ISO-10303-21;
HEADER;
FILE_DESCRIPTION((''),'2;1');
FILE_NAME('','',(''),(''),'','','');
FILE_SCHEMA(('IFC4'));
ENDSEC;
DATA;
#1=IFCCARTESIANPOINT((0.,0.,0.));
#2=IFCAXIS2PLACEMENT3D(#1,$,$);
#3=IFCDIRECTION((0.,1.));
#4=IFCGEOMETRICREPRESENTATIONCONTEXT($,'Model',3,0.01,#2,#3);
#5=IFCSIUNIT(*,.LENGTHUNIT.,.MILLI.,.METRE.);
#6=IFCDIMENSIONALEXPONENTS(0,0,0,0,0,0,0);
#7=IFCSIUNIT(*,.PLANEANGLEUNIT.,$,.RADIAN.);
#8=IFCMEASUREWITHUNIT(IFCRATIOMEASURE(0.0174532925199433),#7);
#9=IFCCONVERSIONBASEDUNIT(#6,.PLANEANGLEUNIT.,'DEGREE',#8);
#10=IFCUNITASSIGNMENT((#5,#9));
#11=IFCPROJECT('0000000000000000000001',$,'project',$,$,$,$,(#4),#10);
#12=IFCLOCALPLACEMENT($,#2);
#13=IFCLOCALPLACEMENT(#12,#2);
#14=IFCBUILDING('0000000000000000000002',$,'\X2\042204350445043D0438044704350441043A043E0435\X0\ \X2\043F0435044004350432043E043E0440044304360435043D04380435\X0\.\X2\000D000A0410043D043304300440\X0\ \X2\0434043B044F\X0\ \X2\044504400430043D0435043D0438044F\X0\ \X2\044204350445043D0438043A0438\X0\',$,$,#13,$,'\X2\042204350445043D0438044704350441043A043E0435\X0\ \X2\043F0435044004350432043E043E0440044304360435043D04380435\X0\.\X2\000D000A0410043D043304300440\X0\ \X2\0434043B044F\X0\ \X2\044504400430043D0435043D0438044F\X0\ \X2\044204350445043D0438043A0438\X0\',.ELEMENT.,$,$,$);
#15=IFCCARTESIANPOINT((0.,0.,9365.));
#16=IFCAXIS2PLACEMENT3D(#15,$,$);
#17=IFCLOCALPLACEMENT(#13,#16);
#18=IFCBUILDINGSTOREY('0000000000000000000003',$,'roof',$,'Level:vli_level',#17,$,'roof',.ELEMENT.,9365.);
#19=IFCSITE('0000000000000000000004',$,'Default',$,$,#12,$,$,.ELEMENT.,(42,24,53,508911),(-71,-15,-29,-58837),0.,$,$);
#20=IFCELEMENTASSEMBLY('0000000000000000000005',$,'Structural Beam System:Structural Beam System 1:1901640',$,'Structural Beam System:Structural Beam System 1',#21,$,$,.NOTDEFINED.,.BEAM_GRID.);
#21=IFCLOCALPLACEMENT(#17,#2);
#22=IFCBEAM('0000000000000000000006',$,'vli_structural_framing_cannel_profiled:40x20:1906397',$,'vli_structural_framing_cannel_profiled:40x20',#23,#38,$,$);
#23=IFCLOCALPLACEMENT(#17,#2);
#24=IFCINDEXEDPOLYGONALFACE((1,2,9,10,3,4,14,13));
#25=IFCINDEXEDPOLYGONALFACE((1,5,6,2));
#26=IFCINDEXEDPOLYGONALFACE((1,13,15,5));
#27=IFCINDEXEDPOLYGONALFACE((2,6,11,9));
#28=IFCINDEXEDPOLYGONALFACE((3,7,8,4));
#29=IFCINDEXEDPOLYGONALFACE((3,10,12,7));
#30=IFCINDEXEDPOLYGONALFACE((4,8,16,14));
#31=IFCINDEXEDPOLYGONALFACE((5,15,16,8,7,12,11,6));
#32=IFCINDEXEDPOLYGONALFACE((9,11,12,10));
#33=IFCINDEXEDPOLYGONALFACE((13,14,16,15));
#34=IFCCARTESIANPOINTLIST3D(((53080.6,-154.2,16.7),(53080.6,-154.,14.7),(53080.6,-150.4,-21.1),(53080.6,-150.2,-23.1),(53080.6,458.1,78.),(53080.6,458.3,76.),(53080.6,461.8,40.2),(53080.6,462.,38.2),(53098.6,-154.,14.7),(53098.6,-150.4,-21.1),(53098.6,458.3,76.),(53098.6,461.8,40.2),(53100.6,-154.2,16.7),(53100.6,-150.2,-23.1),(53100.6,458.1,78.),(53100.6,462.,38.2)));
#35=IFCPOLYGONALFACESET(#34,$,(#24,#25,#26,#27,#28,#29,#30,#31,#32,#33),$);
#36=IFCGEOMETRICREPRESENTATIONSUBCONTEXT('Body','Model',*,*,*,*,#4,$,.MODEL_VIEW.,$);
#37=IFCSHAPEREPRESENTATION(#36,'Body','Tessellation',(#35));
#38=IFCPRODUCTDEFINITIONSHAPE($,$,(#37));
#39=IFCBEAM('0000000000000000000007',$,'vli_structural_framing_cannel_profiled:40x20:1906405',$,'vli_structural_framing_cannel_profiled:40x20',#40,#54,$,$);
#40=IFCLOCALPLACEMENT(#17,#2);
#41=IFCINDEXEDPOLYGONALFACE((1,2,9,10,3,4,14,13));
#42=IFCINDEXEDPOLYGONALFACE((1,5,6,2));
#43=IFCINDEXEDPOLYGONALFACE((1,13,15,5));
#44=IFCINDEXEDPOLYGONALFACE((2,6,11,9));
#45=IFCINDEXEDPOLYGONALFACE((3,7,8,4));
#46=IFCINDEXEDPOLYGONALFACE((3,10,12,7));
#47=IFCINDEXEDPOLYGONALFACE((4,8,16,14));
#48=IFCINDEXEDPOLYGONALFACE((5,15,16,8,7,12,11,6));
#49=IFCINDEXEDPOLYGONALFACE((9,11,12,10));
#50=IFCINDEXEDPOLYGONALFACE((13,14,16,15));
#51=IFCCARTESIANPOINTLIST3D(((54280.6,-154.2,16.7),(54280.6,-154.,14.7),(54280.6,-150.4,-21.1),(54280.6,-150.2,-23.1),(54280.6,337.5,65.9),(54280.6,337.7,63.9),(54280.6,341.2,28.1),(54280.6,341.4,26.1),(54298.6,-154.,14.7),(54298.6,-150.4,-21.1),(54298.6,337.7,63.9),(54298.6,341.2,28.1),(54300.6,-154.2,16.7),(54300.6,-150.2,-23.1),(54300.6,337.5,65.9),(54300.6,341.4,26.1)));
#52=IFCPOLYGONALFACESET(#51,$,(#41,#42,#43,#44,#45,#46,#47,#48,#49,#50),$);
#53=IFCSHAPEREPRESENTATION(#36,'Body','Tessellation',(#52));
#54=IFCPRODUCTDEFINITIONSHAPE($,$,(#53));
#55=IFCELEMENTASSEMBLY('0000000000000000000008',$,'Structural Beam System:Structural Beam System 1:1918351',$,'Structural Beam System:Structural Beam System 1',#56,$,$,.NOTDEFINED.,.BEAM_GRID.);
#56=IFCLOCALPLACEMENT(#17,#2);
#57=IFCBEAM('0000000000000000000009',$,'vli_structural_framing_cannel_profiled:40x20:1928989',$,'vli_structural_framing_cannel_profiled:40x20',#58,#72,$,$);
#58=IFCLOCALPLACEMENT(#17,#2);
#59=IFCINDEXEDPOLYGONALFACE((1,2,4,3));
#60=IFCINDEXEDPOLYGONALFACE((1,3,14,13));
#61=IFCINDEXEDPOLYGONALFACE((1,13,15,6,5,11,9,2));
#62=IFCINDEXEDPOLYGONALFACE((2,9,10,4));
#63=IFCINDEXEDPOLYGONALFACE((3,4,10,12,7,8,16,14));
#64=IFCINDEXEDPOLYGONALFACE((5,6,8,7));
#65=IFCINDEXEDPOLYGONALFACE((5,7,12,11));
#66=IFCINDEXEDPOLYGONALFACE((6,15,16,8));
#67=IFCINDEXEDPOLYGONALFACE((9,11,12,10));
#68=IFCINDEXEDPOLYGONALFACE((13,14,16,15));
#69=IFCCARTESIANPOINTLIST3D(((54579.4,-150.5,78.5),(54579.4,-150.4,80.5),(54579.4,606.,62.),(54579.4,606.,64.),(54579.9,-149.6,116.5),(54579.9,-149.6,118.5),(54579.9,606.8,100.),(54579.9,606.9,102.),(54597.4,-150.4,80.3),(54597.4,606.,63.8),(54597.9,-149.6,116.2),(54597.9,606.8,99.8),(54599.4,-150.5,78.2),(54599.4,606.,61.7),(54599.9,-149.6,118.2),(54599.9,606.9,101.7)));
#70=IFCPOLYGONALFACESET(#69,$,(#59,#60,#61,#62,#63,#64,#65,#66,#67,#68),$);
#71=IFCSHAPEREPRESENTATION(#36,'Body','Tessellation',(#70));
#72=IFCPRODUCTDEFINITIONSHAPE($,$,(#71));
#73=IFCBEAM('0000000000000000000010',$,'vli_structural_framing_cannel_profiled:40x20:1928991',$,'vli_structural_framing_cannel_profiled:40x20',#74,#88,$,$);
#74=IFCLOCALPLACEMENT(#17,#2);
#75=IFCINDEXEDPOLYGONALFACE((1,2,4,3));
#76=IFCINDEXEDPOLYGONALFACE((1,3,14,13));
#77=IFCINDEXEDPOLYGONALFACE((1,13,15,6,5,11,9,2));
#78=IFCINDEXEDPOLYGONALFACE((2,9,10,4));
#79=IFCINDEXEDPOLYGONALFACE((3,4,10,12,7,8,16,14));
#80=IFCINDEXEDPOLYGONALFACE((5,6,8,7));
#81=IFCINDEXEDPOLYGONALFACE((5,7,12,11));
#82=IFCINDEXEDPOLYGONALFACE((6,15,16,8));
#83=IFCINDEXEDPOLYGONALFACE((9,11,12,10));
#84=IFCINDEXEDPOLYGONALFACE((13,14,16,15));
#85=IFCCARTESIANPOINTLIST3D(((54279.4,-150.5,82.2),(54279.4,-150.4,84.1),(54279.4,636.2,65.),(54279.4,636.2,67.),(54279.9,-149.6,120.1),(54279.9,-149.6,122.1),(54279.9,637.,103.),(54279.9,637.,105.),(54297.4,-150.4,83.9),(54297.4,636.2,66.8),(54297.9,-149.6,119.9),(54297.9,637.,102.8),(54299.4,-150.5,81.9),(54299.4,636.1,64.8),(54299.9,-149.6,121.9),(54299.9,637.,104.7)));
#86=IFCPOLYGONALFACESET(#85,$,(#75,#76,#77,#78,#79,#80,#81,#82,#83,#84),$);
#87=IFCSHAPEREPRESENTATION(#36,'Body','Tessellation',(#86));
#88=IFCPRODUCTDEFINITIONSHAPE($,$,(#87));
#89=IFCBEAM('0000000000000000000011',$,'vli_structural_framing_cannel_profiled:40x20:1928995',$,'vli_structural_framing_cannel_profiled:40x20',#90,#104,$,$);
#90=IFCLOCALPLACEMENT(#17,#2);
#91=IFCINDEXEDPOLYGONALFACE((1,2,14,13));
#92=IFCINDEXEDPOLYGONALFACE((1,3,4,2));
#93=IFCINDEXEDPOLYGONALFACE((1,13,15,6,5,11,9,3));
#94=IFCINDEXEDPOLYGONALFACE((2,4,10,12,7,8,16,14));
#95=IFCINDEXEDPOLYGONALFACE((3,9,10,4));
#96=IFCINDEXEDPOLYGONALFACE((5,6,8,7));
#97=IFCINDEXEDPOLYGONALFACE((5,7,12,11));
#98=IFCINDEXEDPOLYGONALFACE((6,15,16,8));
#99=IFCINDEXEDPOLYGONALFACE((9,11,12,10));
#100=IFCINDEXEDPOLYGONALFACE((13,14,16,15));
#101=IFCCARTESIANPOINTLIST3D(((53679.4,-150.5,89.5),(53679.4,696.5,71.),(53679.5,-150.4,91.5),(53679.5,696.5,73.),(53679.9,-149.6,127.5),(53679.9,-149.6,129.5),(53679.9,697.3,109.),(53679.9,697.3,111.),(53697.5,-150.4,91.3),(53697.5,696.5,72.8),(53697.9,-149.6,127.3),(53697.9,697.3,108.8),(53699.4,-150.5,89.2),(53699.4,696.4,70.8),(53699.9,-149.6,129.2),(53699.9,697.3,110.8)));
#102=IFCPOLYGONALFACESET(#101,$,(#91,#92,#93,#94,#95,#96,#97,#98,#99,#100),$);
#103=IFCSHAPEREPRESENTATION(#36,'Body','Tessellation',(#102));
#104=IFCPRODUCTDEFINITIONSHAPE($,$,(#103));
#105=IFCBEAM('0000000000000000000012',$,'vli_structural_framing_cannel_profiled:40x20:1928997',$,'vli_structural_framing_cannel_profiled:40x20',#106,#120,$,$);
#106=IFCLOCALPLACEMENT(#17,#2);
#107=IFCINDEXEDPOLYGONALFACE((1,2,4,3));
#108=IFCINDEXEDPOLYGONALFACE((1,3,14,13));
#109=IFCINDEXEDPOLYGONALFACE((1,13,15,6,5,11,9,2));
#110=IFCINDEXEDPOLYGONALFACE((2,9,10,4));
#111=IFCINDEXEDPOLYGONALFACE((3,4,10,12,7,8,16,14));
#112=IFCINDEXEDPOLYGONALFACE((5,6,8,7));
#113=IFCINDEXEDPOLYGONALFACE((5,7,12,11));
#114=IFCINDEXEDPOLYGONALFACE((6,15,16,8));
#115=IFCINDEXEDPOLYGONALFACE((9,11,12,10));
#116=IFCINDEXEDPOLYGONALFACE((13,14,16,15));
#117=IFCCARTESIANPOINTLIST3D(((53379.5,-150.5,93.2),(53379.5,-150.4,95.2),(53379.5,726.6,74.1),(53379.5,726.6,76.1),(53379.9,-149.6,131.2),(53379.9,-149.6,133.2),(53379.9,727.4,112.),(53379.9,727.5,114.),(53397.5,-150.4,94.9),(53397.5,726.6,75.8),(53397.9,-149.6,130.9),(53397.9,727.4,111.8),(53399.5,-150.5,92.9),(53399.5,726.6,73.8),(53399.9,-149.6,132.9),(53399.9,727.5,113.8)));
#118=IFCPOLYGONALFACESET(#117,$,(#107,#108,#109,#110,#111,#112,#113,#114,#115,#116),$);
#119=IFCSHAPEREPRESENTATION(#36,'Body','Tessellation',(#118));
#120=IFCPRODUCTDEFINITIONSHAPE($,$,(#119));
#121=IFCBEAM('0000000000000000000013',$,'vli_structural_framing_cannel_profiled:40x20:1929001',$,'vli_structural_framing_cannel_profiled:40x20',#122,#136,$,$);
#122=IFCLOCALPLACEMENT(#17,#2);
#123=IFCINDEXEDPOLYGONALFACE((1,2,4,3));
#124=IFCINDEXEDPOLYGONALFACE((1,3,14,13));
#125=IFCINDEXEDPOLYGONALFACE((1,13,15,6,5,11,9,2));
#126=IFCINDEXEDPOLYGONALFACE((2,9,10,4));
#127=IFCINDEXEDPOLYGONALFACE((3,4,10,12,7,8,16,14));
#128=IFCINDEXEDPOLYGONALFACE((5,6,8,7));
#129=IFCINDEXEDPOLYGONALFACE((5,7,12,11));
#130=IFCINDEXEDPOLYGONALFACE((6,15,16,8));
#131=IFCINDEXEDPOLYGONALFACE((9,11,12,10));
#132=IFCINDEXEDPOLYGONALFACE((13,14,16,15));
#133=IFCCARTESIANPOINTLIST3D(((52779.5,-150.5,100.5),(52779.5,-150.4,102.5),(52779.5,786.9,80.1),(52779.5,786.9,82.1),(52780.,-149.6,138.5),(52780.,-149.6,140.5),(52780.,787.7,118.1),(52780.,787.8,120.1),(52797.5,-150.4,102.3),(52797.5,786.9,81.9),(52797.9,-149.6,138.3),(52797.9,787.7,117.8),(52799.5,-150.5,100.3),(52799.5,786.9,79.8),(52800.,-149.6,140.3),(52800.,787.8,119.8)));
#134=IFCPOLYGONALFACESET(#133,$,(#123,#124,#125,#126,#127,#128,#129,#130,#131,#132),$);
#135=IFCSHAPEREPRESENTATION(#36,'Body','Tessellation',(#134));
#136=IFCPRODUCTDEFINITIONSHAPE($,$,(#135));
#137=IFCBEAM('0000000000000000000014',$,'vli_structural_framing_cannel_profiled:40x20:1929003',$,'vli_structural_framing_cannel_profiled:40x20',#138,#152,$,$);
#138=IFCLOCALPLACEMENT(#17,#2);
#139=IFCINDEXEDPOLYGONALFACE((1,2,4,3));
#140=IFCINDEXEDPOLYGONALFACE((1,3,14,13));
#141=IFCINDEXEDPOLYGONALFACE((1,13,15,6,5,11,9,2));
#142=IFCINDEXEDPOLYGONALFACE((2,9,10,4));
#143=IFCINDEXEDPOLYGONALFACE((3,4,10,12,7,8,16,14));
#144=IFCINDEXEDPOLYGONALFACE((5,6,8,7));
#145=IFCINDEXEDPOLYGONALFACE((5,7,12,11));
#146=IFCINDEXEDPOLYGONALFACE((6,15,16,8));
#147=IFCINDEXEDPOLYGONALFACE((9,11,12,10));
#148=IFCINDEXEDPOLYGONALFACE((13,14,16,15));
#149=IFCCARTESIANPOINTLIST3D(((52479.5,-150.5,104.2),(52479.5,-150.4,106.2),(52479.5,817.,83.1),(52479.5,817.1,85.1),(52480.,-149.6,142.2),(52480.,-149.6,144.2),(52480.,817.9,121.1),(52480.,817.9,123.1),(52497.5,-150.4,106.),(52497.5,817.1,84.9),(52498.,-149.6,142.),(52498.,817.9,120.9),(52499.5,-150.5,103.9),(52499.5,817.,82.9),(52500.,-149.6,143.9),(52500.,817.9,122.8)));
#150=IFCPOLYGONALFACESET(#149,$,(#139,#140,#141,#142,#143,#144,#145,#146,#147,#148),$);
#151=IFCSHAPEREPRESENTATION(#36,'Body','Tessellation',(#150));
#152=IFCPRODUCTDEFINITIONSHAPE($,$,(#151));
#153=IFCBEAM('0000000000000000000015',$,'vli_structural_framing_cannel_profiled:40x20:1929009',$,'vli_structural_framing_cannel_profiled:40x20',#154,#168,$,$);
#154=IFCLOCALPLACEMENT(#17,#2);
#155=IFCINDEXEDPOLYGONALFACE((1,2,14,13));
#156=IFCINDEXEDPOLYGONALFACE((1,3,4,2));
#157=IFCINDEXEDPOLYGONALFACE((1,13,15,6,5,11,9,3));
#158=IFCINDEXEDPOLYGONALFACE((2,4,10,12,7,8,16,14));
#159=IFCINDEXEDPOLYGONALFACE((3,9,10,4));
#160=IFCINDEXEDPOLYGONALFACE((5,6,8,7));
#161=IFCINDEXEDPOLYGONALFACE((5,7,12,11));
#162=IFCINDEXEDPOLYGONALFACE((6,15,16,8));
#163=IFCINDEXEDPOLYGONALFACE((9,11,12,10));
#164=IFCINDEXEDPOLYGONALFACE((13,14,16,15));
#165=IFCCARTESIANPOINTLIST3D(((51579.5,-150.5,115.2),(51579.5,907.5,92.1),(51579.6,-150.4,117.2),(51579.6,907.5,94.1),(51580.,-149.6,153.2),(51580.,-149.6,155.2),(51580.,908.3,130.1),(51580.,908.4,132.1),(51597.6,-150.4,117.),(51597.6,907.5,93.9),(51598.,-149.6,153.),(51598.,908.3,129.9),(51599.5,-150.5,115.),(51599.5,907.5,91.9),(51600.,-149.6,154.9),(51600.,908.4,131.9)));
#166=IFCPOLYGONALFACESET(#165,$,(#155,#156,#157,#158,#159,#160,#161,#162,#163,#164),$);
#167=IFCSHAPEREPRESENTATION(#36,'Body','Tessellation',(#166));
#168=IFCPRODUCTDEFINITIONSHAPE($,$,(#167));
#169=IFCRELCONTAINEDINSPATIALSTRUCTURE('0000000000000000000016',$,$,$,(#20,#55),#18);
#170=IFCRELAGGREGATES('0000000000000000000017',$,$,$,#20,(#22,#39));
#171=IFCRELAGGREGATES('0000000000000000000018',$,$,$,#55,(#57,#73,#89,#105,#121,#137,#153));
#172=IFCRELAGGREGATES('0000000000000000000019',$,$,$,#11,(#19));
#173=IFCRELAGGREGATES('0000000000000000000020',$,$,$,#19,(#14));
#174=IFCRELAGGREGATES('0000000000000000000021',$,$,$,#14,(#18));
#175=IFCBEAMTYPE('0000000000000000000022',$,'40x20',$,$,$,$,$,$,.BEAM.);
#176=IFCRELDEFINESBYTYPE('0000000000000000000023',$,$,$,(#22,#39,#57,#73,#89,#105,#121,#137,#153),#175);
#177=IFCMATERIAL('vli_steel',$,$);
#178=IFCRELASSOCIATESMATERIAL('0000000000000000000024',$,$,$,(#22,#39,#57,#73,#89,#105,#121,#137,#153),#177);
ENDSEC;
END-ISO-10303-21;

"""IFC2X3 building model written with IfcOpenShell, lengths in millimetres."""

from ifc_helpers import new_model, entity, si_unit, converted_unit, direction, frame, origin, place, context, subcontext, project, spatial, polyline, outline, extrude, material, type_object, element, aggregate, save


model = new_model("IFC2X3")

# Units and contexts
model_context = context("Model", 3, precision=0.01, world=origin(), true_north=direction((0.0, 1.0)))
body_context = subcontext(model_context, "Body", "Model", "MODEL_VIEW")
ifc_project = project(units=[si_unit("LENGTHUNIT", "METRE", prefix="MILLI"), converted_unit("PLANEANGLEUNIT", "DEGREE", entity("IfcRatioMeasure", 0.0174532925199433), si_unit("PLANEANGLEUNIT", "RADIAN"), dimensions=[0, 0, 0, 0, 0, 0, 0])], contexts=[model_context])

# Site, building, storey
site_placement = place(None, origin())
site = spatial("IfcSite", under=ifc_project, at=site_placement, Name="Default", CompositionType="ELEMENT", RefLatitude=(42, 24, 53, 508911), RefLongitude=(-71, -15, -29, -58837), RefElevation=0.0)
building_placement = place(site_placement, origin())
building = spatial("IfcBuilding", under=site, at=building_placement, Name="Техническое перевооружение.\r\nАнгар для хранения техники", LongName="Техническое перевооружение.\r\nАнгар для хранения техники", CompositionType="ELEMENT")
storey_placement = place(building_placement, frame((0.0, 0.0, 9365.0)))
storey = spatial("IfcBuildingStorey", under=building, at=storey_placement, Name="roof", ObjectType="Level:vli_level", LongName="roof", CompositionType="ELEMENT", Elevation=9365.0)

# Element assemblies, beams
assembly_1_placement = place(storey_placement, origin())
assembly_1 = element("IfcElementAssembly", 1, at=assembly_1_placement, inside=storey, Name="Structural Beam System:Structural Beam System 1:1901640", ObjectType="Structural Beam System:Structural Beam System 1", AssemblyPlace="NOTDEFINED", PredefinedType="BEAM_GRID")
ifc_material = material(Name="vli_steel")
beam_type = type_object("IfcBeamType", Name="40x20", PredefinedType="BEAM")
beam_1_placement = place(assembly_1_placement, frame((53100.0, 462.0, 38.2), z_axis=(0.0, -0.099504, 0.995037), x_axis=(0.0, -0.995037, -0.099504)))
beam_1 = element("IfcBeam", 2, at=beam_1_placement, type_object=beam_type, material=ifc_material, Name="vli_structural_framing_cannel_profiled:40x20:1906397", ObjectType="vli_structural_framing_cannel_profiled:40x20", context=body_context, shape_type="SweptSolid", body=[
    extrude(outline(polyline([(-20.0, -9.5), (-18.0, -9.5), (-18.0, 8.5), (18.0, 8.5), (18.0, -9.5), (20.0, -9.5), (20.0, 10.5), (-20.0, 10.5), (-20.0, -9.5)])), frame((0.0, -9.9, 20.0), z_axis=(1.0, 0.0, 0.0), x_axis=(0.0, 0.0, -1.0)), (0.0, 0.0, 1.0), 615.3),
])
beam_2_placement = place(assembly_1_placement, frame((54300.0, 341.4, 26.1), z_axis=(0.0, -0.099504, 0.995037), x_axis=(0.0, -0.995037, -0.099504)))
beam_2 = element("IfcBeam", 3, at=beam_2_placement, type_object=beam_type, material=ifc_material, Name="vli_structural_framing_cannel_profiled:40x20:1906405", ObjectType="vli_structural_framing_cannel_profiled:40x20", context=body_context, shape_type="SweptSolid", body=[
    extrude(outline(polyline([(-20.0, -9.5), (-18.0, -9.5), (-18.0, 8.5), (18.0, 8.5), (18.0, -9.5), (20.0, -9.5), (20.0, 10.5), (-20.0, 10.5), (-20.0, -9.5)])), frame((0.0, -9.9, 20.0), z_axis=(1.0, 0.0, 0.0), x_axis=(0.0, 0.0, -1.0)), (0.0, 0.0, 1.0), 494.1),
])
aggregate(assembly_1, [beam_1, beam_2])
assembly_2_placement = place(storey_placement, origin())
assembly_2 = element("IfcElementAssembly", 4, at=assembly_2_placement, inside=storey, Name="Structural Beam System:Structural Beam System 1:1918351", ObjectType="Structural Beam System:Structural Beam System 1", AssemblyPlace="NOTDEFINED", PredefinedType="BEAM_GRID")
beam_3_placement = place(assembly_2_placement, frame((54599.3, 607.5, 101.7), z_axis=(0.0, 0.02179, 0.999763), x_axis=(0.0, -0.999763, 0.02179)))
beam_3 = element("IfcBeam", 5, at=beam_3_placement, type_object=beam_type, material=ifc_material, Name="vli_structural_framing_cannel_profiled:40x20:1928989", ObjectType="vli_structural_framing_cannel_profiled:40x20", context=body_context, shape_type="SweptSolid", body=[
    extrude(outline(polyline([(-10.5, -20.0), (9.5, -20.0), (9.5, -18.0), (-8.5, -18.0), (-8.5, 18.0), (9.5, 18.0), (9.5, 20.0), (-10.5, 20.0), (-10.5, -20.0)])), frame((0.7, -10.1, -19.9), z_axis=(1.0, 0.0, 0.0), x_axis=(0.0, -0.999925, 0.012243)), (0.0, 0.0, 1.0), 756.6),
])
beam_4_placement = place(assembly_2_placement, frame((54299.3, 637.7, 104.7), z_axis=(0.0, 0.02179, 0.999763), x_axis=(0.0, -0.999763, 0.02179)))
beam_4 = element("IfcBeam", 6, at=beam_4_placement, type_object=beam_type, material=ifc_material, Name="vli_structural_framing_cannel_profiled:40x20:1928991", ObjectType="vli_structural_framing_cannel_profiled:40x20", context=body_context, shape_type="SweptSolid", body=[
    extrude(outline(polyline([(-10.5, -20.0), (9.5, -20.0), (9.5, -18.0), (-8.5, -18.0), (-8.5, 18.0), (9.5, 18.0), (9.5, 20.0), (-10.5, 20.0), (-10.5, -20.0)])), frame((0.7, -10.1, -19.9), z_axis=(1.0, 0.0, 0.0), x_axis=(0.0, -0.999925, 0.012243)), (0.0, 0.0, 1.0), 786.8),
])
beam_5_placement = place(assembly_2_placement, frame((53699.3, 698.0, 110.8), z_axis=(0.0, 0.02179, 0.999763), x_axis=(0.0, -0.999763, 0.02179)))
beam_5 = element("IfcBeam", 7, at=beam_5_placement, type_object=beam_type, material=ifc_material, Name="vli_structural_framing_cannel_profiled:40x20:1928995", ObjectType="vli_structural_framing_cannel_profiled:40x20", context=body_context, shape_type="SweptSolid", body=[
    extrude(outline(polyline([(-10.5, -20.0), (9.5, -20.0), (9.5, -18.0), (-8.5, -18.0), (-8.5, 18.0), (9.5, 18.0), (9.5, 20.0), (-10.5, 20.0), (-10.5, -20.0)])), frame((0.7, -10.1, -19.9), z_axis=(1.0, 0.0, 0.0), x_axis=(0.0, -0.999925, 0.012243)), (0.0, 0.0, 1.0), 847.1),
])
beam_6_placement = place(assembly_2_placement, frame((53399.3, 728.1, 113.8), z_axis=(0.0, 0.02179, 0.999763), x_axis=(0.0, -0.999763, 0.02179)))
beam_6 = element("IfcBeam", 8, at=beam_6_placement, type_object=beam_type, material=ifc_material, Name="vli_structural_framing_cannel_profiled:40x20:1928997", ObjectType="vli_structural_framing_cannel_profiled:40x20", context=body_context, shape_type="SweptSolid", body=[
    extrude(outline(polyline([(-10.5, -20.0), (9.5, -20.0), (9.5, -18.0), (-8.5, -18.0), (-8.5, 18.0), (9.5, 18.0), (9.5, 20.0), (-10.5, 20.0), (-10.5, -20.0)])), frame((0.7, -10.1, -19.9), z_axis=(1.0, 0.0, 0.0), x_axis=(0.0, -0.999925, 0.012243)), (0.0, 0.0, 1.0), 877.3),
])
beam_7_placement = place(assembly_2_placement, frame((52799.4, 788.4, 119.8), z_axis=(0.0, 0.02179, 0.999763), x_axis=(0.0, -0.999763, 0.02179)))
beam_7 = element("IfcBeam", 9, at=beam_7_placement, type_object=beam_type, material=ifc_material, Name="vli_structural_framing_cannel_profiled:40x20:1929001", ObjectType="vli_structural_framing_cannel_profiled:40x20", context=body_context, shape_type="SweptSolid", body=[
    extrude(outline(polyline([(-10.5, -20.0), (9.5, -20.0), (9.5, -18.0), (-8.5, -18.0), (-8.5, 18.0), (9.5, 18.0), (9.5, 20.0), (-10.5, 20.0), (-10.5, -20.0)])), frame((0.7, -10.1, -19.9), z_axis=(1.0, 0.0, 0.0), x_axis=(0.0, -0.999925, 0.012243)), (0.0, 0.0, 1.0), 937.6),
])
beam_8_placement = place(assembly_2_placement, frame((52499.4, 818.6, 122.8), z_axis=(0.0, 0.02179, 0.999763), x_axis=(0.0, -0.999763, 0.02179)))
beam_8 = element("IfcBeam", 10, at=beam_8_placement, type_object=beam_type, material=ifc_material, Name="vli_structural_framing_cannel_profiled:40x20:1929003", ObjectType="vli_structural_framing_cannel_profiled:40x20", context=body_context, shape_type="SweptSolid", body=[
    extrude(outline(polyline([(-10.5, -20.0), (9.5, -20.0), (9.5, -18.0), (-8.5, -18.0), (-8.5, 18.0), (9.5, 18.0), (9.5, 20.0), (-10.5, 20.0), (-10.5, -20.0)])), frame((0.7, -10.1, -19.9), z_axis=(1.0, 0.0, 0.0), x_axis=(0.0, -0.999925, 0.012243)), (0.0, 0.0, 1.0), 967.7),
])
beam_9_placement = place(assembly_2_placement, frame((51599.4, 909.0, 131.9), z_axis=(0.0, 0.02179, 0.999763), x_axis=(0.0, -0.999763, 0.02179)))
beam_9 = element("IfcBeam", 11, at=beam_9_placement, type_object=beam_type, material=ifc_material, Name="vli_structural_framing_cannel_profiled:40x20:1929009", ObjectType="vli_structural_framing_cannel_profiled:40x20", context=body_context, shape_type="SweptSolid", body=[
    extrude(outline(polyline([(-10.5, -20.0), (9.5, -20.0), (9.5, -18.0), (-8.5, -18.0), (-8.5, 18.0), (9.5, 18.0), (9.5, 20.0), (-10.5, 20.0), (-10.5, -20.0)])), frame((0.7, -10.1, -19.9), z_axis=(1.0, 0.0, 0.0), x_axis=(0.0, -0.999925, 0.012243)), (0.0, 0.0, 1.0), 1058.2),
])
aggregate(assembly_2, [beam_3, beam_4, beam_5, beam_6, beam_7, beam_8, beam_9])

save(model, "model.ifc")
